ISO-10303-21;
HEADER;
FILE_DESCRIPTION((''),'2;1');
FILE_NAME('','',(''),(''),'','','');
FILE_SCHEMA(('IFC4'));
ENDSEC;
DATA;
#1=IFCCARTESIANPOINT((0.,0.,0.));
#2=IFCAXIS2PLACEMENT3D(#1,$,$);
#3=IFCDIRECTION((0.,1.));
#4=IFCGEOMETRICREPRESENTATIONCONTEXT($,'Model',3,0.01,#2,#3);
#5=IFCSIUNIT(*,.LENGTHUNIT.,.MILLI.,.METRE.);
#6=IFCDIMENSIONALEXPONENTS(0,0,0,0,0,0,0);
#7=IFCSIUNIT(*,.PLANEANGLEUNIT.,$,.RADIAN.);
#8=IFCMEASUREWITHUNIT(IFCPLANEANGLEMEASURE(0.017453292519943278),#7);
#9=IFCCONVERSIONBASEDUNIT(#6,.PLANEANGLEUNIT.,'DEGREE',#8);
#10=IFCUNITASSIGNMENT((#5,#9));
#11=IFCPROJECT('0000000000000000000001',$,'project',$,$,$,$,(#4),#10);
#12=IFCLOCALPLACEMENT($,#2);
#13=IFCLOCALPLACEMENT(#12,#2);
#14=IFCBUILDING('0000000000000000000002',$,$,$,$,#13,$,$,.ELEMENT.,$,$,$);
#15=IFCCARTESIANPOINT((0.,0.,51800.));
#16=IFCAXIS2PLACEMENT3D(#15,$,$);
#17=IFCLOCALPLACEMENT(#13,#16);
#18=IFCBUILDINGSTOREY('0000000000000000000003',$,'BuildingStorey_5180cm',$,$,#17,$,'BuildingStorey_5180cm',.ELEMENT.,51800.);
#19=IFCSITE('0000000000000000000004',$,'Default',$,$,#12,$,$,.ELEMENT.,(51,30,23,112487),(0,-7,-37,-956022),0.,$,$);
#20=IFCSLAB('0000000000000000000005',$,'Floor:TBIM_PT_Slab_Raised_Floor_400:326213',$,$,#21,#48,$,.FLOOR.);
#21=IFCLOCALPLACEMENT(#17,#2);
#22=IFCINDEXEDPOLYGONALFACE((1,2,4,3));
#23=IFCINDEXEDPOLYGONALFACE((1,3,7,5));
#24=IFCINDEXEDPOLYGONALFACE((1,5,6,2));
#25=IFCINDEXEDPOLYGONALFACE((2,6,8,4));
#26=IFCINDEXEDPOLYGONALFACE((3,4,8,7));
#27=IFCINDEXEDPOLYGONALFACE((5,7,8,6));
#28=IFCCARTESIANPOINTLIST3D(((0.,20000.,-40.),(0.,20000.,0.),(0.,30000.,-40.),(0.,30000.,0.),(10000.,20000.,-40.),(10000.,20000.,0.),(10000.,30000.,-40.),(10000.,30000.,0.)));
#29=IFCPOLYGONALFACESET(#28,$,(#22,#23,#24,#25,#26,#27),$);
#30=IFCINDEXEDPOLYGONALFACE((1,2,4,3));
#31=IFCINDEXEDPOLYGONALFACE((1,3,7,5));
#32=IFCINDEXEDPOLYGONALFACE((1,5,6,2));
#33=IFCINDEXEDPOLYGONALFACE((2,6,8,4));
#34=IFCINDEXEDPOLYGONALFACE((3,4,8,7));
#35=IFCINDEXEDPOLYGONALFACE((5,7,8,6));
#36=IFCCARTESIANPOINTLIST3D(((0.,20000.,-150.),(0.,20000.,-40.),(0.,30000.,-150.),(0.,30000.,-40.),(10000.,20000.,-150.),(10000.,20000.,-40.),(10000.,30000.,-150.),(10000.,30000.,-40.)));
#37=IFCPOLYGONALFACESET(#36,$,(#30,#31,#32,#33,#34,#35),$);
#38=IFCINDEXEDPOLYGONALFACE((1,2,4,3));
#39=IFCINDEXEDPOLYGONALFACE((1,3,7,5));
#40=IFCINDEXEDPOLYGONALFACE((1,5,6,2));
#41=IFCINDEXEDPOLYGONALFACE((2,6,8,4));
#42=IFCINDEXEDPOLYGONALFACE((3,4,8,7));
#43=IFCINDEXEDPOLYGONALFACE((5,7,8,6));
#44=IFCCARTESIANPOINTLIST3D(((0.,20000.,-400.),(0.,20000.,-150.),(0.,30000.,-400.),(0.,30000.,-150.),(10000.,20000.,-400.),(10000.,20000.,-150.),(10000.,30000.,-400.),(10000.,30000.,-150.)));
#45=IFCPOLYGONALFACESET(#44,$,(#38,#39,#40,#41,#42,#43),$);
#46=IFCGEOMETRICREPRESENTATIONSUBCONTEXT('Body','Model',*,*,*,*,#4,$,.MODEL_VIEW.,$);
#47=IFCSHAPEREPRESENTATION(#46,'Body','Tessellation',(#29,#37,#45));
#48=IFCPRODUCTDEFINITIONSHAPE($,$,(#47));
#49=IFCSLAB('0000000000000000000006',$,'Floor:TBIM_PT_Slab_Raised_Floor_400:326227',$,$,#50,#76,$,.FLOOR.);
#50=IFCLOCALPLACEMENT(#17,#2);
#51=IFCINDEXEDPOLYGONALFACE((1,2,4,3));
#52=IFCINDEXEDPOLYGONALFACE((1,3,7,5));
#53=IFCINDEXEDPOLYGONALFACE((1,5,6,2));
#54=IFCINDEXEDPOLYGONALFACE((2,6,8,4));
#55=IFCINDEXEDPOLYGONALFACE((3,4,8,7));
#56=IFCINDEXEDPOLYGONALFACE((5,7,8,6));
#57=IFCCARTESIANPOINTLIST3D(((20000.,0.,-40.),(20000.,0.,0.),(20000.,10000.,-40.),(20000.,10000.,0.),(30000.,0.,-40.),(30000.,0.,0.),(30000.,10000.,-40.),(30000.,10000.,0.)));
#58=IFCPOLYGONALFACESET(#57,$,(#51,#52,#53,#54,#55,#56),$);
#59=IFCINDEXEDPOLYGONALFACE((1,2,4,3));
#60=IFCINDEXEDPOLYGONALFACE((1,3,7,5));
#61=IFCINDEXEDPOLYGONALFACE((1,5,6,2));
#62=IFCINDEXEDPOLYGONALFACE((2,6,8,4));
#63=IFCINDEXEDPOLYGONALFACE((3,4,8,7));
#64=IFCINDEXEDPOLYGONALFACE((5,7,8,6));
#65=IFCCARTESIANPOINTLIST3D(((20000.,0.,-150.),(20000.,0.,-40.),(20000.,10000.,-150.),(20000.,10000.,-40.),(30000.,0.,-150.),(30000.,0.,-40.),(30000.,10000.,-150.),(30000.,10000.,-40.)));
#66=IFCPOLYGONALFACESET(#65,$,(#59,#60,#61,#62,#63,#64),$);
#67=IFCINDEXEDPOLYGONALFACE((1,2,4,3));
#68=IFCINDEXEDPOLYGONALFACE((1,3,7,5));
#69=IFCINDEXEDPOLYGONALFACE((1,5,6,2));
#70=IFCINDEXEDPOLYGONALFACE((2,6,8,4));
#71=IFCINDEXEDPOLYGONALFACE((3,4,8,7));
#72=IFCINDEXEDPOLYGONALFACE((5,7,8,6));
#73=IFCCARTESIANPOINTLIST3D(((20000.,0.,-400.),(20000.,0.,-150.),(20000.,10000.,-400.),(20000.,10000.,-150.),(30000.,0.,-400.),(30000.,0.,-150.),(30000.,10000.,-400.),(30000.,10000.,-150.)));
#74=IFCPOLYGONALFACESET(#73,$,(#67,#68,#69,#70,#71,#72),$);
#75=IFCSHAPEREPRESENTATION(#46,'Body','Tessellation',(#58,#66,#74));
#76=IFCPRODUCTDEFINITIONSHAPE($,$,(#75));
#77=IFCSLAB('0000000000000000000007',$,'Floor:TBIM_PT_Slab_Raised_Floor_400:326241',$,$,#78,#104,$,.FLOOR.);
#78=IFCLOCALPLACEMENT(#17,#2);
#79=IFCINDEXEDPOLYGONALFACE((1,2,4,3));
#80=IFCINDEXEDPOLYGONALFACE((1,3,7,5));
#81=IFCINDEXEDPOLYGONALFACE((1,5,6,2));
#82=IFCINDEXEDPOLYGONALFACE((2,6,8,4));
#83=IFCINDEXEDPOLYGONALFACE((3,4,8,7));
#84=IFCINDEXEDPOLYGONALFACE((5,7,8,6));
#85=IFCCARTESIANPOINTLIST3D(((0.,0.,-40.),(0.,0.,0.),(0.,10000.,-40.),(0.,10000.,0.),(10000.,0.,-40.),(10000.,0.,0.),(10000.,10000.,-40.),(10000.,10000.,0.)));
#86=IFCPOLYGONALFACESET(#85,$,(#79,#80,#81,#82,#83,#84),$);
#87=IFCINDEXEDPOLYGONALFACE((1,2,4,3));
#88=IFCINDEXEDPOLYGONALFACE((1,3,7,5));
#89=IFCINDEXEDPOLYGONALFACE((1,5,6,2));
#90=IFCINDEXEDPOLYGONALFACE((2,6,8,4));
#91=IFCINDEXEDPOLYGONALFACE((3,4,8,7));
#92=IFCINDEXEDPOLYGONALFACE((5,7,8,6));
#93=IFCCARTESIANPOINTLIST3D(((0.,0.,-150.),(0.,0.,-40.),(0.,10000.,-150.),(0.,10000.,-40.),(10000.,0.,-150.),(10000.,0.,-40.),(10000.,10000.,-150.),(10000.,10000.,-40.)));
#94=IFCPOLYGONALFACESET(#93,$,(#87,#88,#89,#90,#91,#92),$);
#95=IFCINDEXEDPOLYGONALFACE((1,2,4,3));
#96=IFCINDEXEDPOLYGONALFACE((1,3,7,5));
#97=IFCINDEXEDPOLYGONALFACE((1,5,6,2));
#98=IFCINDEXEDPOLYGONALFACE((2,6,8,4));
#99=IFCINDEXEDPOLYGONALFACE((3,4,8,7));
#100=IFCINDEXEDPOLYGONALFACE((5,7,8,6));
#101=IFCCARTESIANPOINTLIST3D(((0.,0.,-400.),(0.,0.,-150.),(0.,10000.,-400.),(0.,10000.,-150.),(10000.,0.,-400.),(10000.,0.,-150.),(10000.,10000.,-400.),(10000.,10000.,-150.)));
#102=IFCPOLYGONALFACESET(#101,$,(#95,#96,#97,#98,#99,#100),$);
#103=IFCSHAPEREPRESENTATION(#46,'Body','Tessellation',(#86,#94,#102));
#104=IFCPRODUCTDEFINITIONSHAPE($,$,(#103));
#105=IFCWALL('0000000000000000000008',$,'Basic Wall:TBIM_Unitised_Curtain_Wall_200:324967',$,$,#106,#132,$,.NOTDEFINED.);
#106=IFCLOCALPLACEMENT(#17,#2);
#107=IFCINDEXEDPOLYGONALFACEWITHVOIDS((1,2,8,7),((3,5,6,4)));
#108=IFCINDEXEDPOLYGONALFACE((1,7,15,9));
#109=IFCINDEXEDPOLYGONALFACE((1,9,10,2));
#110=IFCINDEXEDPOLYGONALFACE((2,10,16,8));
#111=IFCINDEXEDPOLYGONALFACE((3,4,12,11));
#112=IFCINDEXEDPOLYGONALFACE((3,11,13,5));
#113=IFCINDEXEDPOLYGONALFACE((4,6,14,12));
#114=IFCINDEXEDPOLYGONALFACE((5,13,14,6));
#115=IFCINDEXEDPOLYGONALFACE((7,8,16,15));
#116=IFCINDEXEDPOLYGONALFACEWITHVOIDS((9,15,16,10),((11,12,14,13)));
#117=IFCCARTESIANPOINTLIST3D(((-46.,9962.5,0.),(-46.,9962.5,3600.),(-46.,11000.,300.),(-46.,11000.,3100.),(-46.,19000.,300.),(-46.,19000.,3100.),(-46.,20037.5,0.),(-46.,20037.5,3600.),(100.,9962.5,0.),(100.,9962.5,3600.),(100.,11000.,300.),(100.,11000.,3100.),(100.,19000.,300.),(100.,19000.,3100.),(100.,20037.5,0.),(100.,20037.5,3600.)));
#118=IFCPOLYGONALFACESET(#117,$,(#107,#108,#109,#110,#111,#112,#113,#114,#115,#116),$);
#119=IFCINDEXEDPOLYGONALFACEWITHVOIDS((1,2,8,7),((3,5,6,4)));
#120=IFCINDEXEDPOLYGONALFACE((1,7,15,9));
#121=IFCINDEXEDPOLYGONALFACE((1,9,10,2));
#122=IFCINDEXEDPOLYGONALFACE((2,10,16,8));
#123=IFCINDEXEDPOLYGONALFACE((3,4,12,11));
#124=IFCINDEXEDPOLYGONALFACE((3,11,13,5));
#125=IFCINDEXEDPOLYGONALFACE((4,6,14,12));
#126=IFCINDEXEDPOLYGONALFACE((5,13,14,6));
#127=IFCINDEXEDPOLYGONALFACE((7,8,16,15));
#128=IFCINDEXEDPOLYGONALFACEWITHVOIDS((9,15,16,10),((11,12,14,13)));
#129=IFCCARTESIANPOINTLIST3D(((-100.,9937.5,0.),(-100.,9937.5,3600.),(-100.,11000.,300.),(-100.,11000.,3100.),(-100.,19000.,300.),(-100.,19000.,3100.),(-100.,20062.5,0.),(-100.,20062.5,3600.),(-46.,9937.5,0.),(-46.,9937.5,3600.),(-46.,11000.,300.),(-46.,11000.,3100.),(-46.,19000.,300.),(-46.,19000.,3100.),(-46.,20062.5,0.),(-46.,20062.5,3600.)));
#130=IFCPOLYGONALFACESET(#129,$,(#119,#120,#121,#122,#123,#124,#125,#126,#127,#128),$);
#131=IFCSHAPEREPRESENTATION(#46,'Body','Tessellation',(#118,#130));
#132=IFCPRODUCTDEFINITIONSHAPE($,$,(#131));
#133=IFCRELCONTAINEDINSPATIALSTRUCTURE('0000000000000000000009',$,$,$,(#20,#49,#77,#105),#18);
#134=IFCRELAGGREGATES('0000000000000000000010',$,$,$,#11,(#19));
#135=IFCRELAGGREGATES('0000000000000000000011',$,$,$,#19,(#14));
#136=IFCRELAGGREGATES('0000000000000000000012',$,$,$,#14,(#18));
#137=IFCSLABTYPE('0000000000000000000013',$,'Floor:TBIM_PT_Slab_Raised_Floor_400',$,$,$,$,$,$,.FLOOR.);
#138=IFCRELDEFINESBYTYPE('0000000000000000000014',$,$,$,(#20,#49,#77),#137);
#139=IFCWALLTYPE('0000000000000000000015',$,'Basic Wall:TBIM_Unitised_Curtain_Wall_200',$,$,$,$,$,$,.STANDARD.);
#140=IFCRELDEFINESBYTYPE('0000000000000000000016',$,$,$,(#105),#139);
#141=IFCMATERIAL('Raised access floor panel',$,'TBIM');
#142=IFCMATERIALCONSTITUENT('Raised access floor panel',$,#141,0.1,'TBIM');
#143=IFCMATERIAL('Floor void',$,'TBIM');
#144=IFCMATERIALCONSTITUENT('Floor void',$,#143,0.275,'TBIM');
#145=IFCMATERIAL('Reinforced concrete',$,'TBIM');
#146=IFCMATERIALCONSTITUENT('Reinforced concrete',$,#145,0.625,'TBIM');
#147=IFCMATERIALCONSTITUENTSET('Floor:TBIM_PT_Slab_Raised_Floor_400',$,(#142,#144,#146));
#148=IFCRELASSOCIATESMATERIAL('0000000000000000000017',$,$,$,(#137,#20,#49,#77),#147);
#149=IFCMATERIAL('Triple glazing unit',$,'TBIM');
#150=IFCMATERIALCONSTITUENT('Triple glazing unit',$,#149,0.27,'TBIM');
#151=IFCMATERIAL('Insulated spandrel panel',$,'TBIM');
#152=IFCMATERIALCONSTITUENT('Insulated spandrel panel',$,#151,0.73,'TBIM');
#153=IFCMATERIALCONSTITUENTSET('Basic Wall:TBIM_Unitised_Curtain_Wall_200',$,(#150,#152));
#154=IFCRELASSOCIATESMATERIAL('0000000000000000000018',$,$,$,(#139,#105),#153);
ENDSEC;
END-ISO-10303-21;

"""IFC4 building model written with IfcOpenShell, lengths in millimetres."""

from ifc_helpers import new_model, entity, si_unit, converted_unit, direction, frame, origin, place, context, subcontext, project, spatial, indexed_curve, outline, extrude, material, constituent, constituent_set, type_object, element, save


model = new_model("IFC4")

# Units and contexts
model_context = context("Model", 3, precision=0.01, world=origin(), true_north=direction((0.0, 1.0)))
body_context = subcontext(model_context, "Body", "Model", "MODEL_VIEW")
ifc_project = project(units=[si_unit("LENGTHUNIT", "METRE", prefix="MILLI"), converted_unit("PLANEANGLEUNIT", "DEGREE", entity("IfcPlaneAngleMeasure", 0.017453292519943278), si_unit("PLANEANGLEUNIT", "RADIAN"), dimensions=[0, 0, 0, 0, 0, 0, 0])], contexts=[model_context])

# Site, building, storey
site_placement = place(None, origin())
site = spatial("IfcSite", under=ifc_project, at=site_placement, Name="Default", CompositionType="ELEMENT", RefLatitude=(51, 30, 23, 112487), RefLongitude=(0, -7, -37, -956022), RefElevation=0.0)
building_placement = place(site_placement, origin())
building = spatial("IfcBuilding", under=site, at=building_placement, CompositionType="ELEMENT")
storey_placement = place(building_placement, frame((0.0, 0.0, 51800.0)))
storey = spatial("IfcBuildingStorey", under=building, at=storey_placement, Name="BuildingStorey_5180cm", LongName="BuildingStorey_5180cm", CompositionType="ELEMENT", Elevation=51800.0)

# Slabs
ifc_material_1 = material(Name="Raised access floor panel", Category="TBIM")
ifc_constituent_1 = constituent(ifc_material_1, Name="Raised access floor panel", Category="TBIM", fraction=0.1)
ifc_material_2 = material(Name="Floor void", Category="TBIM")
ifc_constituent_2 = constituent(ifc_material_2, Name="Floor void", Category="TBIM", fraction=0.275)
ifc_material_3 = material(Name="Reinforced concrete", Category="TBIM")
ifc_constituent_3 = constituent(ifc_material_3, Name="Reinforced concrete", Category="TBIM", fraction=0.625)
ifc_constituent_set_1 = constituent_set(constituents=[ifc_constituent_1, ifc_constituent_2, ifc_constituent_3], Name="Floor:TBIM_PT_Slab_Raised_Floor_400")
slab_type = type_object("IfcSlabType", Name="Floor:TBIM_PT_Slab_Raised_Floor_400", PredefinedType="FLOOR", material=ifc_constituent_set_1)
slab_1_placement = place(storey_placement, origin())
element("IfcSlab", 1, at=slab_1_placement, inside=storey, type_object=slab_type, material=ifc_constituent_set_1, Name="Floor:TBIM_PT_Slab_Raised_Floor_400:326213", PredefinedType="FLOOR", context=body_context, shape_type="SweptSolid", body=[
    extrude(outline(indexed_curve([(-5000.0, -5000.0), (5000.0, -5000.0), (5000.0, 5000.0), (-5000.0, 5000.0), (-5000.0, -5000.0)], self_intersect=False)), frame((5000.0, 25000.0, -40.0), z_axis=(0.0, 0.0, 1.0), x_axis=(-1.0, 0.0, 0.0)), (0.0, 0.0, 1.0), 40.0),
    extrude(outline(indexed_curve([(-5000.0, -5000.0), (5000.0, -5000.0), (5000.0, 5000.0), (-5000.0, 5000.0), (-5000.0, -5000.0)], self_intersect=False)), frame((5000.0, 25000.0, -150.0), z_axis=(0.0, 0.0, 1.0), x_axis=(-1.0, 0.0, 0.0)), (0.0, 0.0, 1.0), 110.0),
    extrude(outline(indexed_curve([(-5000.0, -5000.0), (5000.0, -5000.0), (5000.0, 5000.0), (-5000.0, 5000.0), (-5000.0, -5000.0)], self_intersect=False)), frame((5000.0, 25000.0, -400.0), z_axis=(0.0, 0.0, 1.0), x_axis=(-1.0, 0.0, 0.0)), (0.0, 0.0, 1.0), 250.0),
])
slab_2_placement = place(storey_placement, origin())
element("IfcSlab", 2, at=slab_2_placement, inside=storey, type_object=slab_type, material=ifc_constituent_set_1, Name="Floor:TBIM_PT_Slab_Raised_Floor_400:326227", PredefinedType="FLOOR", context=body_context, shape_type="SweptSolid", body=[
    extrude(outline(indexed_curve([(-5000.0, -5000.0), (5000.0, -5000.0), (5000.0, 5000.0), (-5000.0, 5000.0), (-5000.0, -5000.0)], self_intersect=False)), frame((25000.0, 5000.0, -40.0), z_axis=(0.0, 0.0, 1.0), x_axis=(-1.0, 0.0, 0.0)), (0.0, 0.0, 1.0), 40.0),
    extrude(outline(indexed_curve([(-5000.0, -5000.0), (5000.0, -5000.0), (5000.0, 5000.0), (-5000.0, 5000.0), (-5000.0, -5000.0)], self_intersect=False)), frame((25000.0, 5000.0, -150.0), z_axis=(0.0, 0.0, 1.0), x_axis=(-1.0, 0.0, 0.0)), (0.0, 0.0, 1.0), 110.0),
    extrude(outline(indexed_curve([(-5000.0, -5000.0), (5000.0, -5000.0), (5000.0, 5000.0), (-5000.0, 5000.0), (-5000.0, -5000.0)], self_intersect=False)), frame((25000.0, 5000.0, -400.0), z_axis=(0.0, 0.0, 1.0), x_axis=(-1.0, 0.0, 0.0)), (0.0, 0.0, 1.0), 250.0),
])
slab_3_placement = place(storey_placement, origin())
element("IfcSlab", 3, at=slab_3_placement, inside=storey, type_object=slab_type, material=ifc_constituent_set_1, Name="Floor:TBIM_PT_Slab_Raised_Floor_400:326241", PredefinedType="FLOOR", context=body_context, shape_type="SweptSolid", body=[
    extrude(outline(indexed_curve([(-5000.0, -5000.0), (5000.0, -5000.0), (5000.0, 5000.0), (-5000.0, 5000.0), (-5000.0, -5000.0)], self_intersect=False)), frame((5000.0, 5000.0, -40.0), z_axis=(0.0, 0.0, 1.0), x_axis=(-1.0, 0.0, 0.0)), (0.0, 0.0, 1.0), 40.0),
    extrude(outline(indexed_curve([(-5000.0, -5000.0), (5000.0, -5000.0), (5000.0, 5000.0), (-5000.0, 5000.0), (-5000.0, -5000.0)], self_intersect=False)), frame((5000.0, 5000.0, -150.0), z_axis=(0.0, 0.0, 1.0), x_axis=(-1.0, 0.0, 0.0)), (0.0, 0.0, 1.0), 110.0),
    extrude(outline(indexed_curve([(-5000.0, -5000.0), (5000.0, -5000.0), (5000.0, 5000.0), (-5000.0, 5000.0), (-5000.0, -5000.0)], self_intersect=False)), frame((5000.0, 5000.0, -400.0), z_axis=(0.0, 0.0, 1.0), x_axis=(-1.0, 0.0, 0.0)), (0.0, 0.0, 1.0), 250.0),
])

# Wall, opening
ifc_material_4 = material(Name="Triple glazing unit", Category="TBIM")
ifc_constituent_4 = constituent(ifc_material_4, Name="Triple glazing unit", Category="TBIM", fraction=0.27)
ifc_material_5 = material(Name="Insulated spandrel panel", Category="TBIM")
ifc_constituent_5 = constituent(ifc_material_5, Name="Insulated spandrel panel", Category="TBIM", fraction=0.73)
ifc_constituent_set_2 = constituent_set(constituents=[ifc_constituent_4, ifc_constituent_5], Name="Basic Wall:TBIM_Unitised_Curtain_Wall_200")
wall_type = type_object("IfcWallType", Name="Basic Wall:TBIM_Unitised_Curtain_Wall_200", PredefinedType="STANDARD", material=ifc_constituent_set_2)
wall_1_placement = place(storey_placement, frame((0.0, 9937.5, 0.0), z_axis=(0.0, 0.0, 1.0), x_axis=(0.0, 1.0, 0.0)))
wall_1 = element("IfcWall", 4, at=wall_1_placement, inside=storey, type_object=wall_type, material=ifc_constituent_set_2, Name="Basic Wall:TBIM_Unitised_Curtain_Wall_200:324967", PredefinedType="NOTDEFINED", context=body_context, shape_type="SweptSolid", body=[
    extrude(outline(indexed_curve([(-1800.0, -5037.5), (1800.0, -5037.5), (1800.0, 5037.5), (-1800.0, 5037.5), (-1800.0, -5037.5)], self_intersect=False), holes=[indexed_curve([(1300.0, 4000.0), (1300.0, -4000.0), (-1500.0, -4000.0), (-1500.0, 4000.0), (1300.0, 4000.0)], self_intersect=False)]), frame((5062.5, 46.0, 1800.0), z_axis=(0.0, -1.0, 0.0), x_axis=(0.0, 0.0, 1.0)), (0.0, 0.0, 1.0), 146.0),
    extrude(outline(indexed_curve([(-5062.5, -1800.0), (5062.5, -1800.0), (5062.5, 1800.0), (-5062.5, 1800.0), (-5062.5, -1800.0)], self_intersect=False), holes=[indexed_curve([(-4000.0, 1300.0), (4000.0, 1300.0), (4000.0, -1500.0), (-4000.0, -1500.0), (-4000.0, 1300.0)], self_intersect=False)]), frame((5062.5, 100.0, 1800.0), z_axis=(0.0, -1.0, 0.0), x_axis=(1.0, 0.0, 0.0)), (0.0, 0.0, 1.0), 54.0),
])
opening_1_placement = place(wall_1_placement, frame((1062.5, -100.0, 300.0)))
element("IfcOpeningElement", 5, at=opening_1_placement, cuts=wall_1, PredefinedType="OPENING", context=body_context, shape_type="SweptSolid", body=[
    extrude(outline(indexed_curve([(2800.0, 0.0), (2800.0, 8000.0), (0.0, 8000.0), (0.0, 0.0), (2800.0, 0.0)], self_intersect=False)), frame((0.0, 0.0, 0.0), z_axis=(0.0, 1.0, 0.0), x_axis=(0.0, 0.0, 1.0)), (0.0, 0.0, 1.0), 200.0),
])

save(model, "model.ifc")
